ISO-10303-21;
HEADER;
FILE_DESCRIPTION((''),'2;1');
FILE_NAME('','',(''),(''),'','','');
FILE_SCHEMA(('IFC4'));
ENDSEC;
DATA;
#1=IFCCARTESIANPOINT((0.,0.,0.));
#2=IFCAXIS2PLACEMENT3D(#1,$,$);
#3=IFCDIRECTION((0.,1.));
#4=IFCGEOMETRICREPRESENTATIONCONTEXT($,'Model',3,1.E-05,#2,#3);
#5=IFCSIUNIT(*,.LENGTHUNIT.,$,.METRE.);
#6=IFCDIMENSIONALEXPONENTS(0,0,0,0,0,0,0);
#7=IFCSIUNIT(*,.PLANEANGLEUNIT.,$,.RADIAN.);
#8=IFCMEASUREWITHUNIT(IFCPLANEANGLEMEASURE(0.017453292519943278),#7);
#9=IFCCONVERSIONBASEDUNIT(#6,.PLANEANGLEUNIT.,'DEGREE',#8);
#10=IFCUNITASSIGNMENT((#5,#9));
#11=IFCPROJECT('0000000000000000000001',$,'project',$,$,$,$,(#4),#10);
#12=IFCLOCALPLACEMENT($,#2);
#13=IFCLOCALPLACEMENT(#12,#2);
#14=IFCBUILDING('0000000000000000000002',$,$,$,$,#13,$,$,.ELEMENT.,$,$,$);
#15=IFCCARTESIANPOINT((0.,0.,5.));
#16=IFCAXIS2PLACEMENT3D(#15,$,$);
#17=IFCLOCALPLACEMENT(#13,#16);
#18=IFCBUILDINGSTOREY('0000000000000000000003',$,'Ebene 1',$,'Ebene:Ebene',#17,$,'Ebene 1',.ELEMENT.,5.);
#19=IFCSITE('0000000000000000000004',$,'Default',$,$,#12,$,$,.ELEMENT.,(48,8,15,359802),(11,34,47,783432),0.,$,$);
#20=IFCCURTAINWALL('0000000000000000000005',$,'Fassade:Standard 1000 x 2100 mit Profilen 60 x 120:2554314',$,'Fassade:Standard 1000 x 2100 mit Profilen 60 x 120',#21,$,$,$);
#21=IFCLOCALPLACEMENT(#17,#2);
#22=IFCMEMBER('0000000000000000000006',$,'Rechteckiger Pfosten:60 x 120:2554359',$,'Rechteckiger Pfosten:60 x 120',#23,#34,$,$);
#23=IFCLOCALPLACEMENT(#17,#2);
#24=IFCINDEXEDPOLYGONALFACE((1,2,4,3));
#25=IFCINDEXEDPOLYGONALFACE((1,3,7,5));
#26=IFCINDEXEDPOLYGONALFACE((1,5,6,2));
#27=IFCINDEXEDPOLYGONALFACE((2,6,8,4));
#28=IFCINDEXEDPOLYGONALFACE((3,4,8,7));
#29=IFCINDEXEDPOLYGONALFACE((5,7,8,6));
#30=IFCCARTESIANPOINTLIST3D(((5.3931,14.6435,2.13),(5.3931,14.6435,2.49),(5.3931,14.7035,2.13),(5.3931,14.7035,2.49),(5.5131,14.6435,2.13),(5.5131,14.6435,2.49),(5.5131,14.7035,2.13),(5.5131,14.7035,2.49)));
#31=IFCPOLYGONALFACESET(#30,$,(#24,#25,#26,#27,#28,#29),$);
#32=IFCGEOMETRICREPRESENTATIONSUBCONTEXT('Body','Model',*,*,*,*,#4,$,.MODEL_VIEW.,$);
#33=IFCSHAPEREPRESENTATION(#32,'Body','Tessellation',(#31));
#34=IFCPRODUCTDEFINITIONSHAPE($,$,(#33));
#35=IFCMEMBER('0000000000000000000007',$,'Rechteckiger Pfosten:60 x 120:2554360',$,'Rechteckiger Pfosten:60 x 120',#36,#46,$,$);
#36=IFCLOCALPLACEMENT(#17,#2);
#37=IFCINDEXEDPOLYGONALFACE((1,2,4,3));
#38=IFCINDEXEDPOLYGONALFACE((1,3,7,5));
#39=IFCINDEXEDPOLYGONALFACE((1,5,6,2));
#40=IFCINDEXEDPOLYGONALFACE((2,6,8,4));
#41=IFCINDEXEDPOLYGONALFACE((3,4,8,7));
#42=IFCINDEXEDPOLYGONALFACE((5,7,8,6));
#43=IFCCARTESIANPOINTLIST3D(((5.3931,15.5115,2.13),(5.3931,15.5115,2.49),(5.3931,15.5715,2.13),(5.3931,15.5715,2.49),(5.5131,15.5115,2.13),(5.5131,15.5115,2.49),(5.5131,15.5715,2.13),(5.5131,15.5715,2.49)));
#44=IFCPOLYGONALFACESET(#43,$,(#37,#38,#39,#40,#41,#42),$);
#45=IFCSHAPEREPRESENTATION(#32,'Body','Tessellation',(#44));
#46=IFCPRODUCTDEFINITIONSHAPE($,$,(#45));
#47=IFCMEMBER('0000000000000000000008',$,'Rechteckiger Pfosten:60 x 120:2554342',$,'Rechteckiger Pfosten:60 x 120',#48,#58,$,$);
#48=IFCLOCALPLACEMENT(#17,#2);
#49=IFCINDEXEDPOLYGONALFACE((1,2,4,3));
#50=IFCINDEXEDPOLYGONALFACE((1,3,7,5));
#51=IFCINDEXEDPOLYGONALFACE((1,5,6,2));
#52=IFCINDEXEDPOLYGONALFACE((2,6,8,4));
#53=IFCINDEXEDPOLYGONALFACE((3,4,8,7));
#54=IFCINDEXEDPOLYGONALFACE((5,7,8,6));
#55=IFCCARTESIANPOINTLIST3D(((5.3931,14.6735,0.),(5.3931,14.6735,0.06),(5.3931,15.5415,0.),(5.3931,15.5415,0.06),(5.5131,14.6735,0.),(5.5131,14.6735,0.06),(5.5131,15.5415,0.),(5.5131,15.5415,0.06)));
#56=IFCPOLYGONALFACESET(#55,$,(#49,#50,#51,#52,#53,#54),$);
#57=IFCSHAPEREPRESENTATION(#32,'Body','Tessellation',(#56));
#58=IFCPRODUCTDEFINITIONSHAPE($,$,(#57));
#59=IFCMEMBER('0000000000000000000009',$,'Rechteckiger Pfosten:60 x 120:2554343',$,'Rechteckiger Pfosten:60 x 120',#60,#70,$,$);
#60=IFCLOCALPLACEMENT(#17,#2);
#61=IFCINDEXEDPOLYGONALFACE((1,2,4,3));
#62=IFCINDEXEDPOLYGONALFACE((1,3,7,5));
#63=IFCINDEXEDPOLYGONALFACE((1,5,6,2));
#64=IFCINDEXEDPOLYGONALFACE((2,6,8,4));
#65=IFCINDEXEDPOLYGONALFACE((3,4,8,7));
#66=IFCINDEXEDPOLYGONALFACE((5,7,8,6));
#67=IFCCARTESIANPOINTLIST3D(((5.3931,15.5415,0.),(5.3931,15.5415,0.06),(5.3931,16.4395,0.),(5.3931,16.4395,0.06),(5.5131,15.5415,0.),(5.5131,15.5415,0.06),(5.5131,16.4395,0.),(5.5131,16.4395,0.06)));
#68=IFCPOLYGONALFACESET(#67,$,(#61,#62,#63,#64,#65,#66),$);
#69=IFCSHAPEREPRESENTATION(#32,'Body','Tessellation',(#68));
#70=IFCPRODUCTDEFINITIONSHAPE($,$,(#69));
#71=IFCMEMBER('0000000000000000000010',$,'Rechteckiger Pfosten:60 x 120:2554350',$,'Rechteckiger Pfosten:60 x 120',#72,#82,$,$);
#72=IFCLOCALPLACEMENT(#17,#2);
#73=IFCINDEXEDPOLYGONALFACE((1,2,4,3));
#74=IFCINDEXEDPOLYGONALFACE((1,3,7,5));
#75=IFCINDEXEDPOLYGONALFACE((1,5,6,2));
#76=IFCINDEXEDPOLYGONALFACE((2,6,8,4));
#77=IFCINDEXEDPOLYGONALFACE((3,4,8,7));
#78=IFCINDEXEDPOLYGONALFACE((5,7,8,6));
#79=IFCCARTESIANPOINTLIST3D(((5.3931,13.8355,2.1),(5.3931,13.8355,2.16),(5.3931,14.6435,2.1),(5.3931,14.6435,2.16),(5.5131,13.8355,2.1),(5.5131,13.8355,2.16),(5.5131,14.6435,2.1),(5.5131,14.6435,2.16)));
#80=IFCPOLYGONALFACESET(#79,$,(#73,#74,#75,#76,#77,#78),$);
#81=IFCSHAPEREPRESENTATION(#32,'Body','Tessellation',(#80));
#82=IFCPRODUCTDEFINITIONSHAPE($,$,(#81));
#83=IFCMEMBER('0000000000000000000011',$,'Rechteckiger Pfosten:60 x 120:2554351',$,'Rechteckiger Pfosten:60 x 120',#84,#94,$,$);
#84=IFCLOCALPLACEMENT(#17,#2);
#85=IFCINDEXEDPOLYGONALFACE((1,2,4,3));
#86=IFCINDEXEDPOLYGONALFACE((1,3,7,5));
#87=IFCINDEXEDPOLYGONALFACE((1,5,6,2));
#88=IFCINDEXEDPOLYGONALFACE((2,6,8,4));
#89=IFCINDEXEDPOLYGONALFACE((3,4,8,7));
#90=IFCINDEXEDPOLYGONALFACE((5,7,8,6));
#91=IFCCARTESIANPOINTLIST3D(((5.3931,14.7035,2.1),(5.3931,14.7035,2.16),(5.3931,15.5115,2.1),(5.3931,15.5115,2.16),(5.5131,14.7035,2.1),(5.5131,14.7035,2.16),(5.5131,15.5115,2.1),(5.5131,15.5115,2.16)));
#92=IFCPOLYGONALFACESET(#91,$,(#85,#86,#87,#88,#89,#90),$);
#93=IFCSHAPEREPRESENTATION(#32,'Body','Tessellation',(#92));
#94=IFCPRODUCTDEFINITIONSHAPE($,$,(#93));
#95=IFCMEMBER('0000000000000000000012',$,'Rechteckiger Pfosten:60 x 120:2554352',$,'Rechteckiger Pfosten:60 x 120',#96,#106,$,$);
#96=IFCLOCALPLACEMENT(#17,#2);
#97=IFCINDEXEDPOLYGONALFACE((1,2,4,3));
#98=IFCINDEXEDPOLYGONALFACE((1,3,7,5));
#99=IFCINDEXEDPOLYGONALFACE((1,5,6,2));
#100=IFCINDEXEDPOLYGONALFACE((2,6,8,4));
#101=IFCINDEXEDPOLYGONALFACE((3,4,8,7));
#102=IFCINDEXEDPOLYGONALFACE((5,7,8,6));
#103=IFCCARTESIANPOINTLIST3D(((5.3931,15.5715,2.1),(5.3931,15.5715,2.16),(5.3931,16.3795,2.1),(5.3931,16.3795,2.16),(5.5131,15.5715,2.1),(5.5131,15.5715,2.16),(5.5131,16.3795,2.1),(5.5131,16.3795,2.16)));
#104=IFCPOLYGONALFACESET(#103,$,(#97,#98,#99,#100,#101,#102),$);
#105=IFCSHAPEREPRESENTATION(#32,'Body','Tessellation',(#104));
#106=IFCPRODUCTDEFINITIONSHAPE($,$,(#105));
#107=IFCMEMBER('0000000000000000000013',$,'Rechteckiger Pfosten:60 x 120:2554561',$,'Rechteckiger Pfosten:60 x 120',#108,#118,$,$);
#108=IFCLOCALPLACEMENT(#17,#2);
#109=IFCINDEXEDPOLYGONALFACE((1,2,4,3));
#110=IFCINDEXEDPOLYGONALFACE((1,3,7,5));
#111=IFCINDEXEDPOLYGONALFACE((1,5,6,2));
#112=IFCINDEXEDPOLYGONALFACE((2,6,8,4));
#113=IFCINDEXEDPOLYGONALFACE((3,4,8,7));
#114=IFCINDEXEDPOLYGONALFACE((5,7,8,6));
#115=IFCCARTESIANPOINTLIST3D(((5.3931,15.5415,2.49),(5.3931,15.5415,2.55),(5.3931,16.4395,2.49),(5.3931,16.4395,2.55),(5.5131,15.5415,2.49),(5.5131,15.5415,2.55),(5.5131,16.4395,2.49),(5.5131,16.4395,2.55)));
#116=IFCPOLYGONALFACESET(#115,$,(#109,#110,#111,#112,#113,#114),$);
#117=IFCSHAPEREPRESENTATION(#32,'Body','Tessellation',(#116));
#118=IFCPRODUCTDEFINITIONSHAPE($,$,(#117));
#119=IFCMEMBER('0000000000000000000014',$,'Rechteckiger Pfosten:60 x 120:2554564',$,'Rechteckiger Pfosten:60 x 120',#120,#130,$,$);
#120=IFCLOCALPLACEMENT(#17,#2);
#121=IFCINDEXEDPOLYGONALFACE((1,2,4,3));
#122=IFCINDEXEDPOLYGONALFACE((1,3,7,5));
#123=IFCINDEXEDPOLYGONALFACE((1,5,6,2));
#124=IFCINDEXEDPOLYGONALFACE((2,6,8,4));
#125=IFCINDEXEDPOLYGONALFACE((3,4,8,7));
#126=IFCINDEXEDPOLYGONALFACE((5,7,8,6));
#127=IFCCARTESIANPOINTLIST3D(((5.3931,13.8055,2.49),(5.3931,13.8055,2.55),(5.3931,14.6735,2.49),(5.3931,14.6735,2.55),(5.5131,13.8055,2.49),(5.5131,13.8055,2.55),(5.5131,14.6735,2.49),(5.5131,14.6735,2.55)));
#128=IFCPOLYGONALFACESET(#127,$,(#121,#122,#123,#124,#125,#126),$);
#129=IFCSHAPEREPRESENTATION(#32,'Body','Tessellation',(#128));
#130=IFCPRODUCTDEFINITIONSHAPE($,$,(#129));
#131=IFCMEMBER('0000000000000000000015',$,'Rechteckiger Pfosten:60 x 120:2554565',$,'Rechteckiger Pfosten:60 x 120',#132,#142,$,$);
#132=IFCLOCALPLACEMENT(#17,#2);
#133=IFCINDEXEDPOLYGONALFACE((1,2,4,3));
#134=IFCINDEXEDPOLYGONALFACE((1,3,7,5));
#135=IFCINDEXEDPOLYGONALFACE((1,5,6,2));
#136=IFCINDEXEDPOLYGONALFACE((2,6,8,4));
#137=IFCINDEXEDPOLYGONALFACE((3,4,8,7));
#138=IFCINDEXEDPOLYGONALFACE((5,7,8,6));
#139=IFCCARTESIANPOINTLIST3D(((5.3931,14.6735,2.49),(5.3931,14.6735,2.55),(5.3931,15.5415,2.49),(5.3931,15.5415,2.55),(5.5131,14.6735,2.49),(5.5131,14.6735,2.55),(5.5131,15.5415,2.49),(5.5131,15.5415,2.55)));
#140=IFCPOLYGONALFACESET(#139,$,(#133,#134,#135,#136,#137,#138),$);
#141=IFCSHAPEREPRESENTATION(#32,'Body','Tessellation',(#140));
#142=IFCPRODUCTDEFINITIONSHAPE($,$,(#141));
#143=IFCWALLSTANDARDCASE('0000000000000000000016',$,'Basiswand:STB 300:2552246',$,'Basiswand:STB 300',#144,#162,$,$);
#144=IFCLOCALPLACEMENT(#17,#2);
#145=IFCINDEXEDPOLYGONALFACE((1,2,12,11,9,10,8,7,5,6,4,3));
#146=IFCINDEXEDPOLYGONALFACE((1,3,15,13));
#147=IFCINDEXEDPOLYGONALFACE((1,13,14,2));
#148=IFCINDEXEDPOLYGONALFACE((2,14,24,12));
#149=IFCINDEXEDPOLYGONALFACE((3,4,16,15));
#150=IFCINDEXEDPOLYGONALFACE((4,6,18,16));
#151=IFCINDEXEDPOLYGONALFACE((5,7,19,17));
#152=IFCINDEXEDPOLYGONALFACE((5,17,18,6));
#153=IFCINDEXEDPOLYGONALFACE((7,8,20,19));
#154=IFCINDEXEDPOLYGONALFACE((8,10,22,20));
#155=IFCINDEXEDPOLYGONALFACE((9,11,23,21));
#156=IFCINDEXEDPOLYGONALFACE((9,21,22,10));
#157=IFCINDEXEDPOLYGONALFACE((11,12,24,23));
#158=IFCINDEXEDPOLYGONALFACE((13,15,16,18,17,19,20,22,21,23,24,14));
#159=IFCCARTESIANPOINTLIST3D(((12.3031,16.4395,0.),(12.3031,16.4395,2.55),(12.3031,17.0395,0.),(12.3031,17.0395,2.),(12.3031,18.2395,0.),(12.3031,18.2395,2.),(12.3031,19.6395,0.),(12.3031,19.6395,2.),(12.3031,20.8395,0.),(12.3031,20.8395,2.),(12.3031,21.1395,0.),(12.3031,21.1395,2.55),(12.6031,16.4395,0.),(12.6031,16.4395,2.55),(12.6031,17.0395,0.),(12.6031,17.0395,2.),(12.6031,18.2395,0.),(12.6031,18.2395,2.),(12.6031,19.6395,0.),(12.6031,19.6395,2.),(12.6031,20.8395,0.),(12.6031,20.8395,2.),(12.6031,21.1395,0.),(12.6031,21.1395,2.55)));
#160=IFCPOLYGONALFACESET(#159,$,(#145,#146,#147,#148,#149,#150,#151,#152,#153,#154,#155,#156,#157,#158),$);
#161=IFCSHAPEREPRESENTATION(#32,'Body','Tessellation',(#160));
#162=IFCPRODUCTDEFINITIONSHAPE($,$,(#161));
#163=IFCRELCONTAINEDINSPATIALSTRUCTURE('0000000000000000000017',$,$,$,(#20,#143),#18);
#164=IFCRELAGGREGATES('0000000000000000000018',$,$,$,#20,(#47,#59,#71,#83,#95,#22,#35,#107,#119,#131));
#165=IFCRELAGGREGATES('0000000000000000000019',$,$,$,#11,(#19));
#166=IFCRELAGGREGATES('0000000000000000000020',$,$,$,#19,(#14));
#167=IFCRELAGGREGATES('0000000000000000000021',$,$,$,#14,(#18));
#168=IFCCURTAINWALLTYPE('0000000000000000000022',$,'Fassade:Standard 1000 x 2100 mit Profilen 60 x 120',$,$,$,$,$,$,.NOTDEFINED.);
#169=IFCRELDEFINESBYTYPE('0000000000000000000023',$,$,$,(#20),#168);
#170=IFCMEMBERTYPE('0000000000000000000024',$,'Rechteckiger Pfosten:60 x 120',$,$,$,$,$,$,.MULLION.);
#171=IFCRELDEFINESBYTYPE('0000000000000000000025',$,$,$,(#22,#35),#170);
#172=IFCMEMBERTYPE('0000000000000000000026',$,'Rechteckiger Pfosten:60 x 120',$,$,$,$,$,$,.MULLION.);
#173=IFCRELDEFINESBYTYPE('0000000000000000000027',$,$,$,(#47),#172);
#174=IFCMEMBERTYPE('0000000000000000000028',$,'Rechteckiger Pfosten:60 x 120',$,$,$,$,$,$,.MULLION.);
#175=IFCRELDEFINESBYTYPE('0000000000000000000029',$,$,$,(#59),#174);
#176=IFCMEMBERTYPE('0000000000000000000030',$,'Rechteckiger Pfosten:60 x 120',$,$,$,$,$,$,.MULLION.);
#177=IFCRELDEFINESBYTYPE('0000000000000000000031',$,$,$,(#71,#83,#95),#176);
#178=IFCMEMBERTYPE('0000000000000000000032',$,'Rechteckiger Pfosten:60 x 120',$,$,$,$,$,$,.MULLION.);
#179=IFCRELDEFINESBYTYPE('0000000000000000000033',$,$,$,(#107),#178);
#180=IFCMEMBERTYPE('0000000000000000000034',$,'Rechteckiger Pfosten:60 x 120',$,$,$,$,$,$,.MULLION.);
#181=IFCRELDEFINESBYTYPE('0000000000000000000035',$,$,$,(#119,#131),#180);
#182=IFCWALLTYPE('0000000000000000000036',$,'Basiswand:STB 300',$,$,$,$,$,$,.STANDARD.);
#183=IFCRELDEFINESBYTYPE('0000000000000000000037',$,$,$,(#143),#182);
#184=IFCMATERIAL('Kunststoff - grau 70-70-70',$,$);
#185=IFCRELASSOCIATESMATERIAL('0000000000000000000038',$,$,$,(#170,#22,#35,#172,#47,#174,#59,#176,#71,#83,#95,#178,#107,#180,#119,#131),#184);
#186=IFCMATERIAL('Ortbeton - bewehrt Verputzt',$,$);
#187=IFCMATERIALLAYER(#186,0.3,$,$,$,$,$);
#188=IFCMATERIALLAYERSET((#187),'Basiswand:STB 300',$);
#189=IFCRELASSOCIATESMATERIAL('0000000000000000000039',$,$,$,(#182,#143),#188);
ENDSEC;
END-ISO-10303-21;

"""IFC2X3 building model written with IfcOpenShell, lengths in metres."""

from ifc_helpers import new_model, entity, si_unit, converted_unit, direction, frame, frame_2d, origin, origin_2d_with_axis, place, context, subcontext, project, spatial, polyline, rectangle, extrude, clip, bounded_halfspace, source, transform, mapped, material, layer, layer_set, layer_usage, type_object, type_shapes, element, aggregate, save


model = new_model("IFC2X3")

# Units and contexts
model_context = context("Model", 3, precision=1e-05, world=origin(), true_north=direction((0.0, 1.0)))
body_context = subcontext(model_context, "Body", "Model", "MODEL_VIEW")
ifc_project = project(units=[si_unit("LENGTHUNIT", "METRE"), converted_unit("PLANEANGLEUNIT", "DEGREE", entity("IfcPlaneAngleMeasure", 0.017453292519943278), si_unit("PLANEANGLEUNIT", "RADIAN"), dimensions=[0, 0, 0, 0, 0, 0, 0])], contexts=[model_context])

# Site, building, storey
site_placement = place(None, origin())
site = spatial("IfcSite", under=ifc_project, at=site_placement, Name="Default", CompositionType="ELEMENT", RefLatitude=(48, 8, 15, 359802), RefLongitude=(11, 34, 47, 783432), RefElevation=0.0)
building_placement = place(site_placement, origin())
building = spatial("IfcBuilding", under=site, at=building_placement, CompositionType="ELEMENT")
storey_placement = place(building_placement, frame((0.0, 0.0, 5.0)))
storey = spatial("IfcBuildingStorey", under=building, at=storey_placement, Name="Ebene 1", ObjectType="Ebene:Ebene", LongName="Ebene 1", CompositionType="ELEMENT", Elevation=5.0)

# Shared definitions
ifc_material_1 = material(Name="Ortbeton - bewehrt Verputzt")

# Curtain wall
curtain_wall_type = type_object("IfcCurtainWallType", Name="Fassade:Standard 1000 x 2100 mit Profilen 60 x 120", PredefinedType="NOTDEFINED")
ifc_material_2 = material(Name="Kunststoff - grau 70-70-70")
curtain_wall_1_placement = place(storey_placement, frame((0.0, 0.0, -5.0)))
curtain_wall_1 = element("IfcCurtainWall", 1, at=curtain_wall_1_placement, inside=storey, type_object=curtain_wall_type, Name="Fassade:Standard 1000 x 2100 mit Profilen 60 x 120:2554314", ObjectType="Fassade:Standard 1000 x 2100 mit Profilen 60 x 120")

# Members
member_type_1 = type_object("IfcMemberType", Name="Rechteckiger Pfosten:60 x 120", PredefinedType="MULLION", material=ifc_material_2)
shared_shape_1 = source(origin(), body_context, "Body", "SweptSolid", [
    extrude(rectangle(XDim=0.06, YDim=0.12, at=frame_2d((0.0, 0.0), x_axis=(1.0, 0.0))), frame((0.0, 0.0, -0.36), z_axis=(0.0, 0.0, 1.0), x_axis=(-1.0, 0.0, 0.0)), (0.0, 0.0, 1.0), 0.36),
])
type_shapes(member_type_1, [shared_shape_1])
member_1_placement = place(curtain_wall_1_placement, frame((5.4531, 14.6735, 7.13), z_axis=(0.0, 0.0, -1.0), x_axis=(0.0, 1.0, 0.0)))
member_1 = element("IfcMember", 2, at=member_1_placement, type_object=member_type_1, material=ifc_material_2, Name="Rechteckiger Pfosten:60 x 120:2554359", ObjectType="Rechteckiger Pfosten:60 x 120", context=body_context, shape_type="MappedRepresentation", body=[
    mapped(shared_shape_1, transform((0.0, 0.0, 0.0), scale=1.0)),
])
member_2_placement = place(curtain_wall_1_placement, frame((5.4531, 15.5415, 7.13), z_axis=(0.0, 0.0, -1.0), x_axis=(0.0, 1.0, 0.0)))
member_2 = element("IfcMember", 3, at=member_2_placement, type_object=member_type_1, material=ifc_material_2, Name="Rechteckiger Pfosten:60 x 120:2554360", ObjectType="Rechteckiger Pfosten:60 x 120", context=body_context, shape_type="MappedRepresentation", body=[
    mapped(shared_shape_1, transform((0.0, 0.0, 0.0), scale=1.0)),
])
member_type_2 = type_object("IfcMemberType", Name="Rechteckiger Pfosten:60 x 120", PredefinedType="MULLION", material=ifc_material_2)
shared_shape_2 = source(origin(), body_context, "Body", "SweptSolid", [
    extrude(rectangle(XDim=0.06, YDim=0.12, at=origin_2d_with_axis()), frame((-0.03, 0.0, -0.868), z_axis=(0.0, 0.0, 1.0), x_axis=(-1.0, 0.0, 0.0)), (0.0, 0.0, 1.0), 0.868),
])
type_shapes(member_type_2, [shared_shape_2])
member_3_placement = place(curtain_wall_1_placement, frame((5.4531, 14.6735, 5.0), z_axis=(0.0, -1.0, 0.0), x_axis=(0.0, 0.0, -1.0)))
member_3 = element("IfcMember", 4, at=member_3_placement, type_object=member_type_2, material=ifc_material_2, Name="Rechteckiger Pfosten:60 x 120:2554342", ObjectType="Rechteckiger Pfosten:60 x 120", context=body_context, shape_type="MappedRepresentation", body=[
    mapped(shared_shape_2, transform((0.0, 0.0, 0.0), scale=1.0)),
])
member_type_3 = type_object("IfcMemberType", Name="Rechteckiger Pfosten:60 x 120", PredefinedType="MULLION", material=ifc_material_2)
shared_shape_3 = source(origin(), body_context, "Body", "SweptSolid", [
    extrude(rectangle(XDim=0.06, YDim=0.12, at=origin_2d_with_axis()), frame((-0.03, 0.0, -0.898), z_axis=(0.0, 0.0, 1.0), x_axis=(-1.0, 0.0, 0.0)), (0.0, 0.0, 1.0), 0.898),
])
type_shapes(member_type_3, [shared_shape_3])
member_4_placement = place(curtain_wall_1_placement, frame((5.4531, 15.5415, 5.0), z_axis=(0.0, -1.0, 0.0), x_axis=(0.0, 0.0, -1.0)))
member_4 = element("IfcMember", 5, at=member_4_placement, type_object=member_type_3, material=ifc_material_2, Name="Rechteckiger Pfosten:60 x 120:2554343", ObjectType="Rechteckiger Pfosten:60 x 120", context=body_context, shape_type="MappedRepresentation", body=[
    mapped(shared_shape_3, transform((0.0, 0.0, 0.0), scale=1.0)),
])
member_type_4 = type_object("IfcMemberType", Name="Rechteckiger Pfosten:60 x 120", PredefinedType="MULLION", material=ifc_material_2)
shared_shape_4 = source(origin(), body_context, "Body", "SweptSolid", [
    extrude(rectangle(XDim=0.06, YDim=0.12, at=origin_2d_with_axis()), frame((0.0, 0.0, -0.808), z_axis=(0.0, 0.0, 1.0), x_axis=(-1.0, 0.0, 0.0)), (0.0, 0.0, 1.0), 0.808),
])
type_shapes(member_type_4, [shared_shape_4])
member_5_placement = place(curtain_wall_1_placement, frame((5.4531, 14.6435, 7.13), z_axis=(0.0, 1.0, 0.0), x_axis=(0.0, 0.0, 1.0)))
member_5 = element("IfcMember", 6, at=member_5_placement, type_object=member_type_4, material=ifc_material_2, Name="Rechteckiger Pfosten:60 x 120:2554350", ObjectType="Rechteckiger Pfosten:60 x 120", context=body_context, shape_type="MappedRepresentation", body=[
    mapped(shared_shape_4, transform((0.0, 0.0, 0.0), scale=1.0)),
])
member_6_placement = place(curtain_wall_1_placement, frame((5.4531, 15.5115, 7.13), z_axis=(0.0, 1.0, 0.0), x_axis=(0.0, 0.0, 1.0)))
member_6 = element("IfcMember", 7, at=member_6_placement, type_object=member_type_4, material=ifc_material_2, Name="Rechteckiger Pfosten:60 x 120:2554351", ObjectType="Rechteckiger Pfosten:60 x 120", context=body_context, shape_type="MappedRepresentation", body=[
    mapped(shared_shape_4, transform((0.0, 0.0, 0.0), scale=1.0)),
])
member_7_placement = place(curtain_wall_1_placement, frame((5.4531, 16.3795, 7.13), z_axis=(0.0, 1.0, 0.0), x_axis=(0.0, 0.0, 1.0)))
member_7 = element("IfcMember", 8, at=member_7_placement, type_object=member_type_4, material=ifc_material_2, Name="Rechteckiger Pfosten:60 x 120:2554352", ObjectType="Rechteckiger Pfosten:60 x 120", context=body_context, shape_type="MappedRepresentation", body=[
    mapped(shared_shape_4, transform((0.0, 0.0, 0.0), scale=1.0)),
])
member_type_5 = type_object("IfcMemberType", Name="Rechteckiger Pfosten:60 x 120", PredefinedType="MULLION", material=ifc_material_2)
shared_shape_5 = source(origin(), body_context, "Body", "SweptSolid", [
    extrude(rectangle(XDim=0.06, YDim=0.12, at=origin_2d_with_axis()), frame((-0.03, 0.0, -0.898), z_axis=(0.0, 0.0, 1.0), x_axis=(-1.0, 0.0, 0.0)), (0.0, 0.0, 1.0), 0.898),
])
type_shapes(member_type_5, [shared_shape_5])
member_8_placement = place(curtain_wall_1_placement, frame((5.4531, 16.4395, 7.55), z_axis=(0.0, 1.0, 0.0), x_axis=(0.0, 0.0, 1.0)))
member_8 = element("IfcMember", 9, at=member_8_placement, type_object=member_type_5, material=ifc_material_2, Name="Rechteckiger Pfosten:60 x 120:2554561", ObjectType="Rechteckiger Pfosten:60 x 120", context=body_context, shape_type="MappedRepresentation", body=[
    mapped(shared_shape_5, transform((0.0, 0.0, 0.0), scale=1.0)),
])
member_type_6 = type_object("IfcMemberType", Name="Rechteckiger Pfosten:60 x 120", PredefinedType="MULLION", material=ifc_material_2)
shared_shape_6 = source(origin(), body_context, "Body", "SweptSolid", [
    extrude(rectangle(XDim=0.06, YDim=0.12, at=origin_2d_with_axis()), frame((-0.03, 0.0, -0.868), z_axis=(0.0, 0.0, 1.0), x_axis=(-1.0, 0.0, 0.0)), (0.0, 0.0, 1.0), 0.868),
])
type_shapes(member_type_6, [shared_shape_6])
member_9_placement = place(curtain_wall_1_placement, frame((5.4531, 14.6735, 7.55), z_axis=(0.0, 1.0, 0.0), x_axis=(0.0, 0.0, 1.0)))
member_9 = element("IfcMember", 10, at=member_9_placement, type_object=member_type_6, material=ifc_material_2, Name="Rechteckiger Pfosten:60 x 120:2554564", ObjectType="Rechteckiger Pfosten:60 x 120", context=body_context, shape_type="MappedRepresentation", body=[
    mapped(shared_shape_6, transform((0.0, 0.0, 0.0), scale=1.0)),
])
member_10_placement = place(curtain_wall_1_placement, frame((5.4531, 15.5415, 7.55), z_axis=(0.0, 1.0, 0.0), x_axis=(0.0, 0.0, 1.0)))
member_10 = element("IfcMember", 11, at=member_10_placement, type_object=member_type_6, material=ifc_material_2, Name="Rechteckiger Pfosten:60 x 120:2554565", ObjectType="Rechteckiger Pfosten:60 x 120", context=body_context, shape_type="MappedRepresentation", body=[
    mapped(shared_shape_6, transform((0.0, 0.0, 0.0), scale=1.0)),
])

aggregate(curtain_wall_1, [member_3, member_4, member_5, member_6, member_7, member_1, member_2, member_8, member_9, member_10])

# Wall, openings
ifc_layer = layer(ifc_material_1, 0.3)
ifc_layer_set = layer_set([ifc_layer], Name="Basiswand:STB 300")
ifc_layer_usage_1 = layer_usage(ifc_layer_set, "AXIS2", "NEGATIVE", 0.15)
wall_type = type_object("IfcWallType", Name="Basiswand:STB 300", PredefinedType="STANDARD", material=ifc_layer_set)
wall_1_placement = place(storey_placement, frame((12.4531, 21.1395, 0.0), z_axis=(0.0, 0.0, 1.0), x_axis=(0.0, -1.0, 0.0)))
wall_1 = element("IfcWallStandardCase", 12, at=wall_1_placement, inside=storey, type_object=wall_type, material=ifc_layer_usage_1, Name="Basiswand:STB 300:2552246", ObjectType="Basiswand:STB 300", context=body_context, shape_type="Clipping", body=[
    clip(extrude(rectangle(XDim=4.7, YDim=0.3, at=frame_2d((2.35, 0.0), x_axis=(-1.0, 0.0))), origin(), (0.0, 0.0, 1.0), 2.55), bounded_halfspace(frame((0.0, -0.15, 2.55), z_axis=(0.0, 0.0, -1.0), x_axis=(1.0, 0.0, 0.0)), True, frame((0.0, -0.15, 2.55)), polyline([(0.0, 0.0), (4.4, 0.0), (4.7, 0.0), (4.7, 0.3), (0.0, 0.3), (0.0, 0.0)]))),
])
opening_1_placement = place(wall_1_placement, frame((21.1395, -12.4531, 0.0), z_axis=(0.0, 0.0, 1.0), x_axis=(0.0, 1.0, 0.0)))
element("IfcOpeningElement", 13, at=opening_1_placement, cuts=wall_1, ObjectType="Opening", context=body_context, shape_type="SweptSolid", body=[
    extrude(rectangle(XDim=2.18, YDim=1.2, at=frame_2d((0.0, 0.0), x_axis=(0.0, 1.0))), frame((10.7791, 20.2395, 0.91), z_axis=(1.0, 0.0, 0.0), x_axis=(0.0, 1.0, 0.0)), (0.0, 0.0, 1.0), 3.048),
])
opening_2_placement = place(wall_1_placement, frame((21.1395, -12.4531, 0.0), z_axis=(0.0, 0.0, 1.0), x_axis=(0.0, 1.0, 0.0)))
element("IfcOpeningElement", 14, at=opening_2_placement, cuts=wall_1, ObjectType="Opening", context=body_context, shape_type="SweptSolid", body=[
    extrude(rectangle(XDim=2.18, YDim=1.2, at=frame_2d((0.0, 0.0), x_axis=(0.0, 1.0))), frame((10.7791, 17.6395, 0.91), z_axis=(1.0, 0.0, 0.0), x_axis=(0.0, 1.0, 0.0)), (0.0, 0.0, 1.0), 3.048),
])

save(model, "model.ifc")
